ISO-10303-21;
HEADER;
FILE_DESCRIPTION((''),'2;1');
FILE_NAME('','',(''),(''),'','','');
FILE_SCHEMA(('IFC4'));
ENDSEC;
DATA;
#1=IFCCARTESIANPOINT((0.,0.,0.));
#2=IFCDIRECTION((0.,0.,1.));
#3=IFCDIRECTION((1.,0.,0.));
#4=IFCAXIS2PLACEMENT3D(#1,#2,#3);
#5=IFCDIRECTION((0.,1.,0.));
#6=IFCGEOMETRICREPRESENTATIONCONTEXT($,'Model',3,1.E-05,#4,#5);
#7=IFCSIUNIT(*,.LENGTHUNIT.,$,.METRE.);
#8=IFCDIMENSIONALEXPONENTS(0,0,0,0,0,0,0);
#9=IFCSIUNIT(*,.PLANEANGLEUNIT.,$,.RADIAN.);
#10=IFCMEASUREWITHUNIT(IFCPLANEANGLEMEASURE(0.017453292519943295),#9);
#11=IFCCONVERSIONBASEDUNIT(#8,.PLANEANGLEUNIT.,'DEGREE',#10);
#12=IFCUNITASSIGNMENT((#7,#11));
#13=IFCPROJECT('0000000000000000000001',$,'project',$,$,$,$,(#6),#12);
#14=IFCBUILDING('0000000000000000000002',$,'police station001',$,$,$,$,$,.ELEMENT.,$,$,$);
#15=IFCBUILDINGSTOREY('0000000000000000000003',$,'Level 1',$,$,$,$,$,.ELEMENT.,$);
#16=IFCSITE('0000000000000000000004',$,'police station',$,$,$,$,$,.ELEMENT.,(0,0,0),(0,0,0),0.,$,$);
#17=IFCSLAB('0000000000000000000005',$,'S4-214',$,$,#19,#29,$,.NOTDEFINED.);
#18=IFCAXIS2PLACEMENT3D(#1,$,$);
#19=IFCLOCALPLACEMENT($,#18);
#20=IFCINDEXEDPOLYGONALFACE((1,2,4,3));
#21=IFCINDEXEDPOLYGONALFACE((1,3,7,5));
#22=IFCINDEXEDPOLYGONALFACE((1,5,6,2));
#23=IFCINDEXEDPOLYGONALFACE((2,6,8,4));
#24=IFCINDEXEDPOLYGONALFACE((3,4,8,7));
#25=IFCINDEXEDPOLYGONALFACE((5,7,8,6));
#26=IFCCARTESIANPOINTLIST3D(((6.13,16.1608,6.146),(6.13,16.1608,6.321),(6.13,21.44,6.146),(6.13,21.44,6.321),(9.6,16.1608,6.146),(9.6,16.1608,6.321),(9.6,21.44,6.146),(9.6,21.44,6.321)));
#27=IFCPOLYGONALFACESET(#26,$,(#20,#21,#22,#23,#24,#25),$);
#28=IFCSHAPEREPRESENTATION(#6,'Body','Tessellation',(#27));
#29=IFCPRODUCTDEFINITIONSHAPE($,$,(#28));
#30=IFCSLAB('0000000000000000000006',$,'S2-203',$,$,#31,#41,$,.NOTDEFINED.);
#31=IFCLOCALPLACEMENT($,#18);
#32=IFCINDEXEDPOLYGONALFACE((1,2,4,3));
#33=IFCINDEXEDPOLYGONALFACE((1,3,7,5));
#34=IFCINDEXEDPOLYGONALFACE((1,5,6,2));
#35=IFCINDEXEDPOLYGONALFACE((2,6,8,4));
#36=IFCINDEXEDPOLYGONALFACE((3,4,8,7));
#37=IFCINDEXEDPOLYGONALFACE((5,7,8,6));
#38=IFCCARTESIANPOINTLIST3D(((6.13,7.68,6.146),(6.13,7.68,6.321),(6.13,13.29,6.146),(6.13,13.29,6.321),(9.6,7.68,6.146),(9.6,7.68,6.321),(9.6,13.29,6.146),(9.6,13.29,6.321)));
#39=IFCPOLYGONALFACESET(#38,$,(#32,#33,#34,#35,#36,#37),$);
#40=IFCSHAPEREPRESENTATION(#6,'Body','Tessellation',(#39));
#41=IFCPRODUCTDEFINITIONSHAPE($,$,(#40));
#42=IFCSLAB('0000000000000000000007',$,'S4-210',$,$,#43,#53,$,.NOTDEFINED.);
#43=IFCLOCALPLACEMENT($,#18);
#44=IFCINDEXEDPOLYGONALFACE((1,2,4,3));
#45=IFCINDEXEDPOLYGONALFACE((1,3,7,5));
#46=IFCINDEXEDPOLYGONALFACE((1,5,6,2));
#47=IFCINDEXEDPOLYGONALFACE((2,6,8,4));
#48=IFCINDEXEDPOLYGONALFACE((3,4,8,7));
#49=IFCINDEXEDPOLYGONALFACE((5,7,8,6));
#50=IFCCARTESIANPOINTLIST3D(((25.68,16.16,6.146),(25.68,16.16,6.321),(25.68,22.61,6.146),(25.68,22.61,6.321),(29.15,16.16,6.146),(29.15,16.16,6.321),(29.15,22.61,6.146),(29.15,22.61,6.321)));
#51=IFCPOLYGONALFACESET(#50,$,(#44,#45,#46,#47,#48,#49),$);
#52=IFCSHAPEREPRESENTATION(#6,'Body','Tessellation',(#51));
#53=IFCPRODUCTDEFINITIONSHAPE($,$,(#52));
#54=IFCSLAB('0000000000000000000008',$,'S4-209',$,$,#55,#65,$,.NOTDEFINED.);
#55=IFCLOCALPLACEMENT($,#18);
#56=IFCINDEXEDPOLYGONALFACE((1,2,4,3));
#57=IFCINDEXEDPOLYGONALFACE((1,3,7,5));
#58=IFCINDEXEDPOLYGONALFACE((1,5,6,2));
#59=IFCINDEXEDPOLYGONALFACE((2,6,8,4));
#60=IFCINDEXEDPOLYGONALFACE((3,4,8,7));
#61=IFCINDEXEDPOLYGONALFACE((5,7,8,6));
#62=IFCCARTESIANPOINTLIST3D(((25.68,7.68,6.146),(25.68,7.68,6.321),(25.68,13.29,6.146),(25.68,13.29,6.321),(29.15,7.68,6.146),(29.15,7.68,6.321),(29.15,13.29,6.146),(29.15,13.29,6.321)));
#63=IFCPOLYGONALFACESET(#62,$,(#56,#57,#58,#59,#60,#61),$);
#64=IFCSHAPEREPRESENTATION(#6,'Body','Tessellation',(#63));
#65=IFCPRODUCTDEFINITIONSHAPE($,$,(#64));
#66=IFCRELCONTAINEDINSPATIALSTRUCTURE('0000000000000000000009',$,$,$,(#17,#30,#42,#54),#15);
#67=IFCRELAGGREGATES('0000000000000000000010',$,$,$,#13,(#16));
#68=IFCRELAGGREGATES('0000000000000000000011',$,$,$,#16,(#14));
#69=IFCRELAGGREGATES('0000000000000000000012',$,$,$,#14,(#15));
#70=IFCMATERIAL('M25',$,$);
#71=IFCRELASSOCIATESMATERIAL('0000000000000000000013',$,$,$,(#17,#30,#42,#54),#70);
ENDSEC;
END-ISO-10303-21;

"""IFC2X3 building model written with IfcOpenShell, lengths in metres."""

from ifc_helpers import new_model, entity, si_unit, converted_unit, direction, frame, frame_2d, origin_with_axes, place, context, project, spatial, rectangle, extrude, material, element, save


model = new_model("IFC2X3")

# Units and contexts
model_context = context("Model", 3, precision=1e-05, world=origin_with_axes(), true_north=direction((0.0, 1.0, 0.0)))
ifc_project = project(units=[si_unit("LENGTHUNIT", "METRE"), converted_unit("PLANEANGLEUNIT", "DEGREE", entity("IfcPlaneAngleMeasure", 0.017453292519943295), si_unit("PLANEANGLEUNIT", "RADIAN"), dimensions=[0, 0, 0, 0, 0, 0, 0])], contexts=[model_context])

# Site, building, storey
site = spatial("IfcSite", under=ifc_project, Name="police station", CompositionType="ELEMENT", RefLatitude=(0, 0, 0), RefLongitude=(0, 0, 0), RefElevation=0.0)
building = spatial("IfcBuilding", under=site, Name="police station001", CompositionType="ELEMENT")
storey = spatial("IfcBuildingStorey", under=building, Name="Level 1", CompositionType="ELEMENT")

# Shared definitions
ifc_material = material(Name="M25")
placement = place(None, origin_with_axes())

# Slabs
element("IfcSlab", 1, at=placement, inside=storey, material=ifc_material, Name="S4-214", PredefinedType="NOTDEFINED", context=model_context, shape_type="SweptSolid", body=[
    extrude(rectangle(XDim=3.47, YDim=5.2792, at=frame_2d((0.0, 0.0), x_axis=(1.0, 0.0, 0.0))), frame((7.865, 18.8004, 6.146), z_axis=(0.0, 0.0, 1.0), x_axis=(1.0, 0.0, 0.0)), (0.0, 0.0, 1.0), 0.175),
])
element("IfcSlab", 2, at=placement, inside=storey, material=ifc_material, Name="S2-203", PredefinedType="NOTDEFINED", context=model_context, shape_type="SweptSolid", body=[
    extrude(rectangle(XDim=3.47, YDim=5.61, at=frame_2d((0.0, 0.0), x_axis=(1.0, 0.0, 0.0))), frame((7.865, 10.485, 6.146), z_axis=(0.0, 0.0, 1.0), x_axis=(1.0, 0.0, 0.0)), (0.0, 0.0, 1.0), 0.175),
])
element("IfcSlab", 3, at=placement, inside=storey, material=ifc_material, Name="S4-210", PredefinedType="NOTDEFINED", context=model_context, shape_type="SweptSolid", body=[
    extrude(rectangle(XDim=3.47, YDim=6.45, at=frame_2d((0.0, 0.0), x_axis=(1.0, 0.0, 0.0))), frame((27.415, 19.385, 6.146), z_axis=(0.0, 0.0, 1.0), x_axis=(1.0, 0.0, 0.0)), (0.0, 0.0, 1.0), 0.175),
])
element("IfcSlab", 4, at=placement, inside=storey, material=ifc_material, Name="S4-209", PredefinedType="NOTDEFINED", context=model_context, shape_type="SweptSolid", body=[
    extrude(rectangle(XDim=3.47, YDim=5.61, at=frame_2d((0.0, 0.0), x_axis=(1.0, 0.0, 0.0))), frame((27.415, 10.485, 6.146), z_axis=(0.0, 0.0, 1.0), x_axis=(1.0, 0.0, 0.0)), (0.0, 0.0, 1.0), 0.175),
])

save(model, "model.ifc")
